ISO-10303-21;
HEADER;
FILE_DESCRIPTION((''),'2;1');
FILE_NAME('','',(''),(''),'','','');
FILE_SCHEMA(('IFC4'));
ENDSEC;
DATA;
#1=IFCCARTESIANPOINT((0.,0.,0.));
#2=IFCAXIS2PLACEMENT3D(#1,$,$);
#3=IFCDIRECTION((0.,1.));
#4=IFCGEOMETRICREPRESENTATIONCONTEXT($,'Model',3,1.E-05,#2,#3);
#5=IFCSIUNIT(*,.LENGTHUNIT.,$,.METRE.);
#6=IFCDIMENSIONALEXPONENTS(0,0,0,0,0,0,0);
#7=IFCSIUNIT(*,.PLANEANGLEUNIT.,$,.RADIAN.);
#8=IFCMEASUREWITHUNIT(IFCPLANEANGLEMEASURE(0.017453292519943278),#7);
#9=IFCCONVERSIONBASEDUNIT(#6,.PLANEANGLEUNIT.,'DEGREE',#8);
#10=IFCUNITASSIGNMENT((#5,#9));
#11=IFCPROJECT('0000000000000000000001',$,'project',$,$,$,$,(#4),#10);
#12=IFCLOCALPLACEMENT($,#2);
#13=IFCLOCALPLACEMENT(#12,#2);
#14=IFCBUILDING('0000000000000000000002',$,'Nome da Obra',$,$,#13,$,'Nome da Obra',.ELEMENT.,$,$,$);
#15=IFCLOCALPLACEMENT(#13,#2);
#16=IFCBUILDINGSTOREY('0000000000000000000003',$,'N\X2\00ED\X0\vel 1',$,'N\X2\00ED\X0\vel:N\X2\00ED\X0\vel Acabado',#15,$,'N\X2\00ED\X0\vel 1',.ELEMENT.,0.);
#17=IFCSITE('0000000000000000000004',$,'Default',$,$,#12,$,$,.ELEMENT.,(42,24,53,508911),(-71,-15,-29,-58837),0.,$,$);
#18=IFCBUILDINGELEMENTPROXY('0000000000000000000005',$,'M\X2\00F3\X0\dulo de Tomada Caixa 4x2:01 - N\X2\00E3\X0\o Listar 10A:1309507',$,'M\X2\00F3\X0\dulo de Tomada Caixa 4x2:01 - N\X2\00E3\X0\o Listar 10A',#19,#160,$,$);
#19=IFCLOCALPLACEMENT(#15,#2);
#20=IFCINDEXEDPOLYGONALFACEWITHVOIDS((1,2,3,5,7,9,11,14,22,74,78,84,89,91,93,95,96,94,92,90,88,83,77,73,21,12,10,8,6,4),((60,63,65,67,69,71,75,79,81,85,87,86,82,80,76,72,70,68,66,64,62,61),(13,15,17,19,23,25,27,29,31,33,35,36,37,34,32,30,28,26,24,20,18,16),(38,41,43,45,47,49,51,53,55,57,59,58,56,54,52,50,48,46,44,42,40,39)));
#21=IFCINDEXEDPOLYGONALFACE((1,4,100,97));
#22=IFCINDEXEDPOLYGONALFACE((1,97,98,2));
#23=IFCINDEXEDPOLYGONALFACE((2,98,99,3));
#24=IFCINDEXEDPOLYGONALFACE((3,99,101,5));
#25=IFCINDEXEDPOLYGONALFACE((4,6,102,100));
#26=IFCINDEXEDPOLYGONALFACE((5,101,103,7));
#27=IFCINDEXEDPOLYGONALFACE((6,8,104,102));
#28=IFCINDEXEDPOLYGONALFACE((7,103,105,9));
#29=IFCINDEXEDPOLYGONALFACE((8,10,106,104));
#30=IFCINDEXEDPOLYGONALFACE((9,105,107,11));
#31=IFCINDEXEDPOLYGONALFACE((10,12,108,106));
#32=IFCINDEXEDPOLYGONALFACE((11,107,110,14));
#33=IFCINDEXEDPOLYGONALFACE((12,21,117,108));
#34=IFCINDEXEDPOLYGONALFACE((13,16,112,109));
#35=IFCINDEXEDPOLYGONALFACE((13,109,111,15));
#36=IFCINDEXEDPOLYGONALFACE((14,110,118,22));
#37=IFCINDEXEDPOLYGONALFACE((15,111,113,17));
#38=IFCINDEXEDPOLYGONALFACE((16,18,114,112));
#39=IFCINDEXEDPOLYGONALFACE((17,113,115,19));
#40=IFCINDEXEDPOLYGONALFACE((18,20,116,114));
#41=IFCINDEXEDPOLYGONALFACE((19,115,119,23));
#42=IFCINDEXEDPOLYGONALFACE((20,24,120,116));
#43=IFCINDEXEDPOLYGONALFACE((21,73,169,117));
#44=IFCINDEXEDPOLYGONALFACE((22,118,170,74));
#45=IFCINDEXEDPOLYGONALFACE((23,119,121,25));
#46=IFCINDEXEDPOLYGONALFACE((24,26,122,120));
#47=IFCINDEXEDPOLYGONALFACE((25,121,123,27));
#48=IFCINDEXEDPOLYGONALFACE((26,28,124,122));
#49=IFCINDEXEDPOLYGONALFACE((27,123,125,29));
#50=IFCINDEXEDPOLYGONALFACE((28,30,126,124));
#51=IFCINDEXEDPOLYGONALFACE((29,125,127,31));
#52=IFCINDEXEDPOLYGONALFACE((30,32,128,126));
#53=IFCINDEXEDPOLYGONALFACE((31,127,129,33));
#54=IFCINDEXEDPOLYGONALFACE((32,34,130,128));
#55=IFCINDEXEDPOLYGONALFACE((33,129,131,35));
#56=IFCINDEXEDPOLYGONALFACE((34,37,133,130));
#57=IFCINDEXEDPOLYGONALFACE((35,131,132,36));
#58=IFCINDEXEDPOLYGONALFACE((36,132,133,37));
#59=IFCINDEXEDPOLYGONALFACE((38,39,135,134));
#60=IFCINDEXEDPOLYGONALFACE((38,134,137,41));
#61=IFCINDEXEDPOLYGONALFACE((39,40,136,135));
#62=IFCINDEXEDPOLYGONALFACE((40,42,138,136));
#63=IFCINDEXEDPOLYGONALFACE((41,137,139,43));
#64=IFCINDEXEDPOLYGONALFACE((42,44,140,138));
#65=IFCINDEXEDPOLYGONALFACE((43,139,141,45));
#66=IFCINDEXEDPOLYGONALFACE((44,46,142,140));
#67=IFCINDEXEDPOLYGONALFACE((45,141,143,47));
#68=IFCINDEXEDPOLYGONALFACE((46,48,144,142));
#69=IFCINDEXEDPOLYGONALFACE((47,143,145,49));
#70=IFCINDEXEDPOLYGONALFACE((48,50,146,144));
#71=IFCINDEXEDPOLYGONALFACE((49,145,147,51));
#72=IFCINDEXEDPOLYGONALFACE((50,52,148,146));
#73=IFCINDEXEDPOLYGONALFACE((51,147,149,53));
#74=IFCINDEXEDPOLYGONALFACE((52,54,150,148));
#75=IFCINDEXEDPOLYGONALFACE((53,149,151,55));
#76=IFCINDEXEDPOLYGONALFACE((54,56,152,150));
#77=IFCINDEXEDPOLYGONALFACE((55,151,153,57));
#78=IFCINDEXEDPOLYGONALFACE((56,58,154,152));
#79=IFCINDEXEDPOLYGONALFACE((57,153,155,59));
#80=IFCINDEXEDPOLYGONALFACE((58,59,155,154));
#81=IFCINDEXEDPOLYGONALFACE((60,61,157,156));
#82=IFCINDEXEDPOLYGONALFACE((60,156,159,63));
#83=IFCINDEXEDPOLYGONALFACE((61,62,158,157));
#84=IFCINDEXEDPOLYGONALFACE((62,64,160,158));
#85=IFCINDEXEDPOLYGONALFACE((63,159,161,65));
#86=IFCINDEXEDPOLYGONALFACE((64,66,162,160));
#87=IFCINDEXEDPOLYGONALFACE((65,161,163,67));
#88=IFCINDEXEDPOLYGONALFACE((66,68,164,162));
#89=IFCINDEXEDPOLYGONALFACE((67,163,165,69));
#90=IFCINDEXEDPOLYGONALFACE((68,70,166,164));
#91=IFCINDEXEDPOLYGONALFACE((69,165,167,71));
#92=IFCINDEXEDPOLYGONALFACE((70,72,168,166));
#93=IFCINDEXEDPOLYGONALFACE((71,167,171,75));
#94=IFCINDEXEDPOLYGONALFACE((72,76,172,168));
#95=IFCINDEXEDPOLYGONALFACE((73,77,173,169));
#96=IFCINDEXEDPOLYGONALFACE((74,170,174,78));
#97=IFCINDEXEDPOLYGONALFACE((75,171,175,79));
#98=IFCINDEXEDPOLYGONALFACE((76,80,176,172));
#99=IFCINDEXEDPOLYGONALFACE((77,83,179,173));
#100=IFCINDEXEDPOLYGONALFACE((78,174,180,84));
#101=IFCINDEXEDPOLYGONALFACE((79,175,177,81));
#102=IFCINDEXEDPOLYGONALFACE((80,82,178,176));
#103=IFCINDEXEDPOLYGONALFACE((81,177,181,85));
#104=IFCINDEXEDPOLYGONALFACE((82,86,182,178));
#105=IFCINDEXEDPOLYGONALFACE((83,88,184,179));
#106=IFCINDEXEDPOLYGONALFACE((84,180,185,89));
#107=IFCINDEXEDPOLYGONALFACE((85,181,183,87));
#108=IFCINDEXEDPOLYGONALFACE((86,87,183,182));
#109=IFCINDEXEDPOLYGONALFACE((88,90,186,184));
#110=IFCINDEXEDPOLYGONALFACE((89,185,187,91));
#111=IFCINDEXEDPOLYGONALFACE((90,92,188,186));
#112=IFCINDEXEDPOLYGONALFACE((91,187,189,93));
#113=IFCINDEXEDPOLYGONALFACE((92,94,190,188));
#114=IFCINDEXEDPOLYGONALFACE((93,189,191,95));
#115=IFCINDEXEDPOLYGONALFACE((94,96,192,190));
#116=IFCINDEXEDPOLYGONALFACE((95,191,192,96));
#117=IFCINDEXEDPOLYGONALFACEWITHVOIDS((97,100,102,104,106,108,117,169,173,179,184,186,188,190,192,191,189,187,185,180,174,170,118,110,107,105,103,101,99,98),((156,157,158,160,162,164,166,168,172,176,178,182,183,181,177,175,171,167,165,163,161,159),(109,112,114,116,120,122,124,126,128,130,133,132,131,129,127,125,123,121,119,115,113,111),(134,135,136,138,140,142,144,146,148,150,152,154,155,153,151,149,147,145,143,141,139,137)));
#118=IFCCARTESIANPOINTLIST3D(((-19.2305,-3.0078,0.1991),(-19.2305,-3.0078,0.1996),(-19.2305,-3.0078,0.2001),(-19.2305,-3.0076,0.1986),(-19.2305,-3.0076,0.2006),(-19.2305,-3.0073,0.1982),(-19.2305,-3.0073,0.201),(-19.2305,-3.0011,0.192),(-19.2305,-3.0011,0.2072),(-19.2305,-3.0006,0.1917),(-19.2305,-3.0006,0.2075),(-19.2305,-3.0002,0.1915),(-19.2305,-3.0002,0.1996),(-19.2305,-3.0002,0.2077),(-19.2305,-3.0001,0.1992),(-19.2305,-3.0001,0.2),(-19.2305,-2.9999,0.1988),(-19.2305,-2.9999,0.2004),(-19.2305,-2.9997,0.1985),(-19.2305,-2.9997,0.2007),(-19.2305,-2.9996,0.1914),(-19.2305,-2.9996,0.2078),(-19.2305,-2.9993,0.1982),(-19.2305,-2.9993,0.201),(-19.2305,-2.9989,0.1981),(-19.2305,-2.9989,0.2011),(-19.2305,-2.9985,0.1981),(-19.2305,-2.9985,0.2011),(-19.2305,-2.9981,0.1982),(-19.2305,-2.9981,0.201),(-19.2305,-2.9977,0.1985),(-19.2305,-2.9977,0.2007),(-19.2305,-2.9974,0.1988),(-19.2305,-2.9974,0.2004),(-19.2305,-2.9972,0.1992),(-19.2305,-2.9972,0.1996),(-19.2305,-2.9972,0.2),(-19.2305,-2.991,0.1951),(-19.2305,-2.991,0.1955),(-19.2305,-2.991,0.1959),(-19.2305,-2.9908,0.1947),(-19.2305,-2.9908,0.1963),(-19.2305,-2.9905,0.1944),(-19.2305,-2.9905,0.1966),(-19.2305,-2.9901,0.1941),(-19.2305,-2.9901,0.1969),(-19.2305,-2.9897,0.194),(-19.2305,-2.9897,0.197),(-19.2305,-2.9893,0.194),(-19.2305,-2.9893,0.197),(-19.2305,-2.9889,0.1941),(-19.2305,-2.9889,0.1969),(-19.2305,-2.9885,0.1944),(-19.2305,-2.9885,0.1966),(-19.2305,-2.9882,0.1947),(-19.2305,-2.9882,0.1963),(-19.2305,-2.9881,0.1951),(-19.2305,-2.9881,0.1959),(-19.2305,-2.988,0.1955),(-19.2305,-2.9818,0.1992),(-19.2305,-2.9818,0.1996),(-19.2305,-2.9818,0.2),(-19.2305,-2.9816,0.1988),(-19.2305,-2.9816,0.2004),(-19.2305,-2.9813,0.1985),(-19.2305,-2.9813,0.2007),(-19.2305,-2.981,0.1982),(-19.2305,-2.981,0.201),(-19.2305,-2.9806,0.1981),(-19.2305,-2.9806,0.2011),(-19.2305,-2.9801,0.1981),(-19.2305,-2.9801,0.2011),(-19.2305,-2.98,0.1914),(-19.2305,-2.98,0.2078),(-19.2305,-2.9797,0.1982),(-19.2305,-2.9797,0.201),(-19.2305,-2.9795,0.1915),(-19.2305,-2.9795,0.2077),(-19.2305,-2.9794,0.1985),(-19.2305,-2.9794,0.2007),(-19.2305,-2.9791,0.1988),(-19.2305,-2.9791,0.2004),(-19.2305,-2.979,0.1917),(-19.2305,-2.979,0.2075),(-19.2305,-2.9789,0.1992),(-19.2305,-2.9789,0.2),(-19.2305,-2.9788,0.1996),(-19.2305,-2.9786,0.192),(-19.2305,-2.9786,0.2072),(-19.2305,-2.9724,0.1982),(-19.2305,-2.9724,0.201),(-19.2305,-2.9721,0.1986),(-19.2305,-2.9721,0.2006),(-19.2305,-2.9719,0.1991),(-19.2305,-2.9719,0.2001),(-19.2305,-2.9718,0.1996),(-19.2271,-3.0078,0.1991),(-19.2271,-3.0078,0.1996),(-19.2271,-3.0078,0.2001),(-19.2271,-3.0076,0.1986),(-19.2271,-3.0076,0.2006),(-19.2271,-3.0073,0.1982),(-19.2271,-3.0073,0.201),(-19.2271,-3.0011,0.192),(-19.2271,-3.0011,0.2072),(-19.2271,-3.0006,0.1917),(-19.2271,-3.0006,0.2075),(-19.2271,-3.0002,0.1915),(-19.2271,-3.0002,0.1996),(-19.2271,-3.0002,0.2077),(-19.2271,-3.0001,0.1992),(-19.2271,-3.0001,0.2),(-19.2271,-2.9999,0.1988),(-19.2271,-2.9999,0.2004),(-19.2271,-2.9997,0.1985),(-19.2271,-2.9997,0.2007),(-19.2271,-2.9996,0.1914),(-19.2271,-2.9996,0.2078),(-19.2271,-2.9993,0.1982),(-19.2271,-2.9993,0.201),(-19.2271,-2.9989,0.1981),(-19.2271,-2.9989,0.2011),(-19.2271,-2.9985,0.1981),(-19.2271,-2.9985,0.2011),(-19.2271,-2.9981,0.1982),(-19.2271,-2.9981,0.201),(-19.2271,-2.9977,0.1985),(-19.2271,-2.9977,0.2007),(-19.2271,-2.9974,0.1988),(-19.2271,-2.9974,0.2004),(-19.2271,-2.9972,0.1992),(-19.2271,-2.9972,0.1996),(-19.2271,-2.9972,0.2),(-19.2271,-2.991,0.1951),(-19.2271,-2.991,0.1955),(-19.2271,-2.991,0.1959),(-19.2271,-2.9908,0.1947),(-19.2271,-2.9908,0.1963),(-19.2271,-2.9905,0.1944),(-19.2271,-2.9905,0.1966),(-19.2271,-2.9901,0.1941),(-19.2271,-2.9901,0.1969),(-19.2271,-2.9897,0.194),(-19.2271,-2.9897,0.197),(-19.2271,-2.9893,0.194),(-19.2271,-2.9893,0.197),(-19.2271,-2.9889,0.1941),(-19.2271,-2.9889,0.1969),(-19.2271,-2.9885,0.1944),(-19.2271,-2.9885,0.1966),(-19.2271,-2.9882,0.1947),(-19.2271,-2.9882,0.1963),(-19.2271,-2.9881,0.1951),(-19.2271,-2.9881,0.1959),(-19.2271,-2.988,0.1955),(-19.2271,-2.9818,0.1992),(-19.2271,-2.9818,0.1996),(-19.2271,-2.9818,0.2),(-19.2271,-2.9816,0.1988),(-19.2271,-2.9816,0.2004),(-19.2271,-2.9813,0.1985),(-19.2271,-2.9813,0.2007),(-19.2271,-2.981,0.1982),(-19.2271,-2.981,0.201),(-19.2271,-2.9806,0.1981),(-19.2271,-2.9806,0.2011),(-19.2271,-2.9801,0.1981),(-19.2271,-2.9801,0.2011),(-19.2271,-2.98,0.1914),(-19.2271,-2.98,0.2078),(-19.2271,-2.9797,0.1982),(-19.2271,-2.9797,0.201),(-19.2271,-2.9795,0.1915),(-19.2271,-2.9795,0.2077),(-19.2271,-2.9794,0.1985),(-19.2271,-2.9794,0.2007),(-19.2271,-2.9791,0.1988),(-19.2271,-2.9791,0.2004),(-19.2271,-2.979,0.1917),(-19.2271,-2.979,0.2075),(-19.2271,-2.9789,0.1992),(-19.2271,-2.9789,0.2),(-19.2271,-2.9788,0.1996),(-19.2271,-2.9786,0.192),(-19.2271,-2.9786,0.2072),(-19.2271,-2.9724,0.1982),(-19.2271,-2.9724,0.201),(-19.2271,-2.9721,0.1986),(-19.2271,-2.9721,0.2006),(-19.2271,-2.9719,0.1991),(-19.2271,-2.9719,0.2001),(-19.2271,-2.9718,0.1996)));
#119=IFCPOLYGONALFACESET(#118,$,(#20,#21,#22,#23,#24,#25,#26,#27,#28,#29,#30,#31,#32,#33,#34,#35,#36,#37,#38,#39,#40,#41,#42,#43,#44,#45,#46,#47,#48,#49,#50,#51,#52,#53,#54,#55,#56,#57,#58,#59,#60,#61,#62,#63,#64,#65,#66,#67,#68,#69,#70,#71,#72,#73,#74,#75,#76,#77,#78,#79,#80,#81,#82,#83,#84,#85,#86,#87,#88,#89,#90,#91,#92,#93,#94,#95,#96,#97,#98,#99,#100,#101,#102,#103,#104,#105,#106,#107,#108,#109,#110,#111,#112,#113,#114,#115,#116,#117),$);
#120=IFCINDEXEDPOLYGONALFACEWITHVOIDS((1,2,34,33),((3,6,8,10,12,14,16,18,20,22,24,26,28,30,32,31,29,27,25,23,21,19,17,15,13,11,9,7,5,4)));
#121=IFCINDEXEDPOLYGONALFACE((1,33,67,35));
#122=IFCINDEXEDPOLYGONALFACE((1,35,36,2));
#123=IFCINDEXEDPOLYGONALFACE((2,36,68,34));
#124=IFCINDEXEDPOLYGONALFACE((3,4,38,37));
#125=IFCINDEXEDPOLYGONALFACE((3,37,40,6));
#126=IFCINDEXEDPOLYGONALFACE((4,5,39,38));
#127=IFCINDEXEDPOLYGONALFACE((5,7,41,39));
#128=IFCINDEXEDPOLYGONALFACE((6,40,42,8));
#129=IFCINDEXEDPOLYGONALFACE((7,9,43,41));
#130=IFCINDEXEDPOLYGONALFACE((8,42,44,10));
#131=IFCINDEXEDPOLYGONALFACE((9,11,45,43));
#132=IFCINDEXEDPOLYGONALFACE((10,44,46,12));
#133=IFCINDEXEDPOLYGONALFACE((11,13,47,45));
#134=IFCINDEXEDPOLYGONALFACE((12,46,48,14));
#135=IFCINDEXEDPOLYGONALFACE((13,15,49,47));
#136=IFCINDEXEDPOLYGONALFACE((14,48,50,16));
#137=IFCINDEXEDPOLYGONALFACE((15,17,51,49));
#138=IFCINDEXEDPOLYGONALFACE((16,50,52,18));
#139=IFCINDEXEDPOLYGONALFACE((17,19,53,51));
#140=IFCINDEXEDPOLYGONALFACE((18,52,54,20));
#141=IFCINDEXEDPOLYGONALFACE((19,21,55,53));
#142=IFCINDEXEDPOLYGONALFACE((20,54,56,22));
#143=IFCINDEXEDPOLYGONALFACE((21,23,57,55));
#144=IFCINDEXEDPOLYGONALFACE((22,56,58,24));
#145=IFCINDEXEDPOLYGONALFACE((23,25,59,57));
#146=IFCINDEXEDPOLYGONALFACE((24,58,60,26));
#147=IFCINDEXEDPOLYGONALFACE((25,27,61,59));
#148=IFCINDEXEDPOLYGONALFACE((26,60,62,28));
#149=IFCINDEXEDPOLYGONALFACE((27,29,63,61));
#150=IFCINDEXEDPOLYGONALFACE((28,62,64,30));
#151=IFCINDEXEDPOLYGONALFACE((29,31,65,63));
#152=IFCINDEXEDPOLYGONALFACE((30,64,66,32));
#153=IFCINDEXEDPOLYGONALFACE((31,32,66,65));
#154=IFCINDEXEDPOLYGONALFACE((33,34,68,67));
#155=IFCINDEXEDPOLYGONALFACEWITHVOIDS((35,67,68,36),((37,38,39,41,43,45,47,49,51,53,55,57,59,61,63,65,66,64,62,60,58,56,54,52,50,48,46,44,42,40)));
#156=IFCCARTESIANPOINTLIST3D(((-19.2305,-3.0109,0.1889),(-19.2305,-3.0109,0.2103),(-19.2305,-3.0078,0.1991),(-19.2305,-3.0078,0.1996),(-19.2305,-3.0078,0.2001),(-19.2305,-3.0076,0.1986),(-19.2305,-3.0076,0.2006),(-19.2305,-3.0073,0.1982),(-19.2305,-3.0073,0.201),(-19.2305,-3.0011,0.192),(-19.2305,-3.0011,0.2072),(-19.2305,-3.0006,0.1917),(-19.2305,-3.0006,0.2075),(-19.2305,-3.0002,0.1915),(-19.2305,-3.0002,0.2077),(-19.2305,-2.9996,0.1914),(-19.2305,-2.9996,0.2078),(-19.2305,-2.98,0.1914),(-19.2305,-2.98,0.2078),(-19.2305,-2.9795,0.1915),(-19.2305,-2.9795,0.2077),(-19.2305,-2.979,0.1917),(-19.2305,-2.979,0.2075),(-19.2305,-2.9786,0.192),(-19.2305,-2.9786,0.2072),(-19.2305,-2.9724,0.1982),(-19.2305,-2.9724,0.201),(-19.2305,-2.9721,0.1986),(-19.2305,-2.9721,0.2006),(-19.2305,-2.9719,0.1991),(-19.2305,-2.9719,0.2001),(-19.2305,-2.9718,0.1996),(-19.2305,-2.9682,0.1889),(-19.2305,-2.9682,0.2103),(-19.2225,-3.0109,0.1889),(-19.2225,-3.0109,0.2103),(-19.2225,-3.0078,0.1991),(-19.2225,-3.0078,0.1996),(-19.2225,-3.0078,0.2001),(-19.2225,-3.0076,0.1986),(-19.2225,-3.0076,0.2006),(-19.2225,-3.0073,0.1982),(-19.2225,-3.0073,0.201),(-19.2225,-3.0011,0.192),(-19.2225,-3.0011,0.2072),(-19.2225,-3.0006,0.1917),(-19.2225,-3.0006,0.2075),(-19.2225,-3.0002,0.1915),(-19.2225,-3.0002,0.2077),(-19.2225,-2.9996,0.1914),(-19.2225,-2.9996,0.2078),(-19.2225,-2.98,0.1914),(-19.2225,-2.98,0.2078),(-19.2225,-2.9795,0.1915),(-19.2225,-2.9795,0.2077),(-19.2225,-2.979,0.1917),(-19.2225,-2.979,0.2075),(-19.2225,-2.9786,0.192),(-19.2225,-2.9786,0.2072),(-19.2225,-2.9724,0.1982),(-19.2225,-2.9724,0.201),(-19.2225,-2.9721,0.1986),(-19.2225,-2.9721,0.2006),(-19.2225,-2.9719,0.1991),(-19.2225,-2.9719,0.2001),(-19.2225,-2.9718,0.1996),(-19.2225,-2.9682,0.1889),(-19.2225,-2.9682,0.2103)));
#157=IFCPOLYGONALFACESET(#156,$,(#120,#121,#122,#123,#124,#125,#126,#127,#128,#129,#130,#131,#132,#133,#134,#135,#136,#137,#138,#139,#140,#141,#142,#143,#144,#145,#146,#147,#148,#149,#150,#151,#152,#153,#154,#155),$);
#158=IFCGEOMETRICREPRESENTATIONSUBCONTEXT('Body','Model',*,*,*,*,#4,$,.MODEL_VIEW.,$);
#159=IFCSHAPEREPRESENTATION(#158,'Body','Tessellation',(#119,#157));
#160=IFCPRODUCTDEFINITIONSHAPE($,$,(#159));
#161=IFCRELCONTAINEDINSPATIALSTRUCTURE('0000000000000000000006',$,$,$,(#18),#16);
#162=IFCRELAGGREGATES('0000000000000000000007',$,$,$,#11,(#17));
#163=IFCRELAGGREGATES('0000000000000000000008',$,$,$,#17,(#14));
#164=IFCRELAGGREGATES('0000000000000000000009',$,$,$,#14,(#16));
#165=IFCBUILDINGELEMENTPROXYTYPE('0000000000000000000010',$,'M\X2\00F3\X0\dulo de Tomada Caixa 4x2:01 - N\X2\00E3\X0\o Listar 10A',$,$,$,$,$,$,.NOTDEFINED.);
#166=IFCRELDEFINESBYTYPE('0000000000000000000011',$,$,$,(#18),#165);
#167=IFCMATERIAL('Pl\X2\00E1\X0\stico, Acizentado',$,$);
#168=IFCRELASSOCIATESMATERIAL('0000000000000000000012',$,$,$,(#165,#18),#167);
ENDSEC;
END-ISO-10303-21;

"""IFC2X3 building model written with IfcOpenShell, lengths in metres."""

from ifc_helpers import new_model, entity, si_unit, converted_unit, direction, frame, frame_2d, origin, place, context, subcontext, project, spatial, polyline, circle_curve, parameter, trimmed, segment, composite_curve, outline, extrude, source, transform, mapped, material, type_object, type_shapes, element, save


model = new_model("IFC2X3")

# Units and contexts
model_context = context("Model", 3, precision=1e-05, world=origin(), true_north=direction((0.0, 1.0)))
body_context = subcontext(model_context, "Body", "Model", "MODEL_VIEW")
ifc_project = project(units=[si_unit("LENGTHUNIT", "METRE"), converted_unit("PLANEANGLEUNIT", "DEGREE", entity("IfcPlaneAngleMeasure", 0.017453292519943278), si_unit("PLANEANGLEUNIT", "RADIAN"), dimensions=[0, 0, 0, 0, 0, 0, 0])], contexts=[model_context])

# Site, building, storey
site_placement = place(None, origin())
site = spatial("IfcSite", under=ifc_project, at=site_placement, Name="Default", CompositionType="ELEMENT", RefLatitude=(42, 24, 53, 508911), RefLongitude=(-71, -15, -29, -58837), RefElevation=0.0)
building_placement = place(site_placement, origin())
building = spatial("IfcBuilding", under=site, at=building_placement, Name="Nome da Obra", LongName="Nome da Obra", CompositionType="ELEMENT")
storey_placement = place(building_placement, origin())
storey = spatial("IfcBuildingStorey", under=building, at=storey_placement, Name="Nível 1", ObjectType="Nível:Nível Acabado", LongName="Nível 1", CompositionType="ELEMENT", Elevation=0.0)

# Building element proxy
ifc_material_1 = material(Name="Plástico, Acizentado")
building_element_proxy_type_1 = type_object("IfcBuildingElementProxyType", Name="Módulo de Tomada Caixa 4x2:01 - Não Listar 10A", PredefinedType="NOTDEFINED", material=ifc_material_1)
shared_shape_1 = source(origin(), body_context, "Body", "SweptSolid", [
    extrude(outline(composite_curve([segment(polyline([(-0.0098, -0.0082), (0.0098, -0.0082)]), True, "CONTINUOUS"), segment(trimmed(circle_curve(frame_2d((0.0098, -0.0062), x_axis=(1.0, 0.0)), 0.002), [parameter(270.0)], [parameter(315.0)], True, "PARAMETER"), True, "CONTINUOUS"), segment(polyline([(0.0112, -0.0076), (0.0174, -0.0014)]), True, "CONTINUOUS"), segment(trimmed(circle_curve(frame_2d((0.016, 0.0), x_axis=(1.0, 0.0)), 0.002), [parameter(315.0)], [parameter(45.0)], True, "PARAMETER"), True, "CONTINUOUS"), segment(polyline([(0.0174, 0.0014), (0.0112, 0.0076)]), True, "CONTINUOUS"), segment(trimmed(circle_curve(frame_2d((0.0098, 0.0062), x_axis=(1.0, 0.0)), 0.002), [parameter(45.0)], [parameter(90.0)], True, "PARAMETER"), True, "CONTINUOUS"), segment(polyline([(0.0098, 0.0082), (-0.0098, 0.0082)]), True, "CONTINUOUS"), segment(trimmed(circle_curve(frame_2d((-0.0098, 0.0062), x_axis=(1.0, 0.0)), 0.002), [parameter(90.0)], [parameter(135.0)], True, "PARAMETER"), True, "CONTINUOUS"), segment(polyline([(-0.0112, 0.0076), (-0.0174, 0.0014)]), True, "CONTINUOUS"), segment(trimmed(circle_curve(frame_2d((-0.016, 0.0), x_axis=(1.0, 0.0)), 0.002), [parameter(135.0)], [parameter(225.0)], True, "PARAMETER"), True, "CONTINUOUS"), segment(polyline([(-0.0174, -0.0014), (-0.0112, -0.0076)]), True, "CONTINUOUS"), segment(trimmed(circle_curve(frame_2d((-0.0098, -0.0062), x_axis=(1.0, 0.0)), 0.002), [parameter(225.0)], [parameter(270.0)], True, "PARAMETER"), True, "CONTINUOUS")], self_intersect=False), holes=[composite_curve([segment(trimmed(circle_curve(frame_2d((0.0089, 0.0), x_axis=(1.0, 0.0)), 0.0015), [parameter(0.0)], [parameter(180.0)], True, "PARAMETER"), False, "CONTINUOUS"), segment(trimmed(circle_curve(frame_2d((0.0089, 0.0), x_axis=(1.0, 0.0)), 0.0015), [parameter(180.0)], [parameter(0.0)], True, "PARAMETER"), False, "CONTINUOUS")], self_intersect=False), composite_curve([segment(trimmed(circle_curve(frame_2d((-0.0003, 0.0041), x_axis=(1.0, 0.0)), 0.0015), [parameter(0.0)], [parameter(180.0)], True, "PARAMETER"), False, "CONTINUOUS"), segment(trimmed(circle_curve(frame_2d((-0.0003, 0.0041), x_axis=(1.0, 0.0)), 0.0015), [parameter(180.0)], [parameter(0.0)], True, "PARAMETER"), False, "CONTINUOUS")], self_intersect=False), composite_curve([segment(trimmed(circle_curve(frame_2d((-0.0095, 0.0), x_axis=(1.0, 0.0)), 0.0015), [parameter(0.0)], [parameter(180.0)], True, "PARAMETER"), False, "CONTINUOUS"), segment(trimmed(circle_curve(frame_2d((-0.0095, 0.0), x_axis=(1.0, 0.0)), 0.0015), [parameter(180.0)], [parameter(0.0)], True, "PARAMETER"), False, "CONTINUOUS")], self_intersect=False)]), frame((0.0003, 0.0, 0.125), z_axis=(0.0, 1.0, 0.0), x_axis=(1.0, 0.0, 0.0)), (0.0, 0.0, 1.0), 0.0034),
    extrude(outline(polyline([(-0.0214, -0.0107), (0.0214, -0.0107), (0.0214, 0.0107), (-0.0214, 0.0107), (-0.0214, -0.0107)]), holes=[composite_curve([segment(polyline([(0.0101, -0.0082), (-0.0095, -0.0082)]), True, "CONTINUOUS"), segment(trimmed(circle_curve(frame_2d((-0.0095, -0.0062), x_axis=(1.0, 0.0)), 0.002), [parameter(225.0)], [parameter(270.0)], True, "PARAMETER"), False, "CONTINUOUS"), segment(polyline([(-0.0109, -0.0076), (-0.0171, -0.0014)]), True, "CONTINUOUS"), segment(trimmed(circle_curve(frame_2d((-0.0157, 0.0), x_axis=(1.0, 0.0)), 0.002), [parameter(135.0)], [parameter(225.0)], True, "PARAMETER"), False, "CONTINUOUS"), segment(polyline([(-0.0171, 0.0014), (-0.0109, 0.0076)]), True, "CONTINUOUS"), segment(trimmed(circle_curve(frame_2d((-0.0095, 0.0062), x_axis=(1.0, 0.0)), 0.002), [parameter(90.0)], [parameter(135.0)], True, "PARAMETER"), False, "CONTINUOUS"), segment(polyline([(-0.0095, 0.0082), (0.0101, 0.0082)]), True, "CONTINUOUS"), segment(trimmed(circle_curve(frame_2d((0.0101, 0.0062), x_axis=(1.0, 0.0)), 0.002), [parameter(45.0)], [parameter(90.0)], True, "PARAMETER"), False, "CONTINUOUS"), segment(polyline([(0.0115, 0.0076), (0.0177, 0.0014)]), True, "CONTINUOUS"), segment(trimmed(circle_curve(frame_2d((0.0163, 0.0), x_axis=(1.0, 0.0)), 0.002), [parameter(315.0)], [parameter(45.0)], True, "PARAMETER"), False, "CONTINUOUS"), segment(polyline([(0.0177, -0.0014), (0.0115, -0.0076)]), True, "CONTINUOUS"), segment(trimmed(circle_curve(frame_2d((0.0101, -0.0062), x_axis=(1.0, 0.0)), 0.002), [parameter(270.0)], [parameter(315.0)], True, "PARAMETER"), False, "CONTINUOUS")], self_intersect=False)]), frame((0.0, 0.0, 0.125), z_axis=(0.0, 1.0, 0.0), x_axis=(1.0, 0.0, 0.0)), (0.0, 0.0, 1.0), 0.008),
])
type_shapes(building_element_proxy_type_1, [shared_shape_1])
for number, where, z_axis, x_axis, name in (
    (1, (-19.2305, -2.9895, 0.0746), (0.0, 0.0, 1.0), (0.0, -1.0, 0.0), "Módulo de Tomada Caixa 4x2:01 - Não Listar 10A:1309507"),
):
    element("IfcBuildingElementProxy", number, at=place(storey_placement, frame(where, z_axis=z_axis, x_axis=x_axis)), inside=storey, type_object=building_element_proxy_type_1, material=ifc_material_1, Name=name, ObjectType="Módulo de Tomada Caixa 4x2:01 - Não Listar 10A", context=body_context, shape_type="MappedRepresentation", body=[
        mapped(shared_shape_1, transform((0.0, 0.0, 0.0), scale=1.0)),
    ])

save(model, "model.ifc")
